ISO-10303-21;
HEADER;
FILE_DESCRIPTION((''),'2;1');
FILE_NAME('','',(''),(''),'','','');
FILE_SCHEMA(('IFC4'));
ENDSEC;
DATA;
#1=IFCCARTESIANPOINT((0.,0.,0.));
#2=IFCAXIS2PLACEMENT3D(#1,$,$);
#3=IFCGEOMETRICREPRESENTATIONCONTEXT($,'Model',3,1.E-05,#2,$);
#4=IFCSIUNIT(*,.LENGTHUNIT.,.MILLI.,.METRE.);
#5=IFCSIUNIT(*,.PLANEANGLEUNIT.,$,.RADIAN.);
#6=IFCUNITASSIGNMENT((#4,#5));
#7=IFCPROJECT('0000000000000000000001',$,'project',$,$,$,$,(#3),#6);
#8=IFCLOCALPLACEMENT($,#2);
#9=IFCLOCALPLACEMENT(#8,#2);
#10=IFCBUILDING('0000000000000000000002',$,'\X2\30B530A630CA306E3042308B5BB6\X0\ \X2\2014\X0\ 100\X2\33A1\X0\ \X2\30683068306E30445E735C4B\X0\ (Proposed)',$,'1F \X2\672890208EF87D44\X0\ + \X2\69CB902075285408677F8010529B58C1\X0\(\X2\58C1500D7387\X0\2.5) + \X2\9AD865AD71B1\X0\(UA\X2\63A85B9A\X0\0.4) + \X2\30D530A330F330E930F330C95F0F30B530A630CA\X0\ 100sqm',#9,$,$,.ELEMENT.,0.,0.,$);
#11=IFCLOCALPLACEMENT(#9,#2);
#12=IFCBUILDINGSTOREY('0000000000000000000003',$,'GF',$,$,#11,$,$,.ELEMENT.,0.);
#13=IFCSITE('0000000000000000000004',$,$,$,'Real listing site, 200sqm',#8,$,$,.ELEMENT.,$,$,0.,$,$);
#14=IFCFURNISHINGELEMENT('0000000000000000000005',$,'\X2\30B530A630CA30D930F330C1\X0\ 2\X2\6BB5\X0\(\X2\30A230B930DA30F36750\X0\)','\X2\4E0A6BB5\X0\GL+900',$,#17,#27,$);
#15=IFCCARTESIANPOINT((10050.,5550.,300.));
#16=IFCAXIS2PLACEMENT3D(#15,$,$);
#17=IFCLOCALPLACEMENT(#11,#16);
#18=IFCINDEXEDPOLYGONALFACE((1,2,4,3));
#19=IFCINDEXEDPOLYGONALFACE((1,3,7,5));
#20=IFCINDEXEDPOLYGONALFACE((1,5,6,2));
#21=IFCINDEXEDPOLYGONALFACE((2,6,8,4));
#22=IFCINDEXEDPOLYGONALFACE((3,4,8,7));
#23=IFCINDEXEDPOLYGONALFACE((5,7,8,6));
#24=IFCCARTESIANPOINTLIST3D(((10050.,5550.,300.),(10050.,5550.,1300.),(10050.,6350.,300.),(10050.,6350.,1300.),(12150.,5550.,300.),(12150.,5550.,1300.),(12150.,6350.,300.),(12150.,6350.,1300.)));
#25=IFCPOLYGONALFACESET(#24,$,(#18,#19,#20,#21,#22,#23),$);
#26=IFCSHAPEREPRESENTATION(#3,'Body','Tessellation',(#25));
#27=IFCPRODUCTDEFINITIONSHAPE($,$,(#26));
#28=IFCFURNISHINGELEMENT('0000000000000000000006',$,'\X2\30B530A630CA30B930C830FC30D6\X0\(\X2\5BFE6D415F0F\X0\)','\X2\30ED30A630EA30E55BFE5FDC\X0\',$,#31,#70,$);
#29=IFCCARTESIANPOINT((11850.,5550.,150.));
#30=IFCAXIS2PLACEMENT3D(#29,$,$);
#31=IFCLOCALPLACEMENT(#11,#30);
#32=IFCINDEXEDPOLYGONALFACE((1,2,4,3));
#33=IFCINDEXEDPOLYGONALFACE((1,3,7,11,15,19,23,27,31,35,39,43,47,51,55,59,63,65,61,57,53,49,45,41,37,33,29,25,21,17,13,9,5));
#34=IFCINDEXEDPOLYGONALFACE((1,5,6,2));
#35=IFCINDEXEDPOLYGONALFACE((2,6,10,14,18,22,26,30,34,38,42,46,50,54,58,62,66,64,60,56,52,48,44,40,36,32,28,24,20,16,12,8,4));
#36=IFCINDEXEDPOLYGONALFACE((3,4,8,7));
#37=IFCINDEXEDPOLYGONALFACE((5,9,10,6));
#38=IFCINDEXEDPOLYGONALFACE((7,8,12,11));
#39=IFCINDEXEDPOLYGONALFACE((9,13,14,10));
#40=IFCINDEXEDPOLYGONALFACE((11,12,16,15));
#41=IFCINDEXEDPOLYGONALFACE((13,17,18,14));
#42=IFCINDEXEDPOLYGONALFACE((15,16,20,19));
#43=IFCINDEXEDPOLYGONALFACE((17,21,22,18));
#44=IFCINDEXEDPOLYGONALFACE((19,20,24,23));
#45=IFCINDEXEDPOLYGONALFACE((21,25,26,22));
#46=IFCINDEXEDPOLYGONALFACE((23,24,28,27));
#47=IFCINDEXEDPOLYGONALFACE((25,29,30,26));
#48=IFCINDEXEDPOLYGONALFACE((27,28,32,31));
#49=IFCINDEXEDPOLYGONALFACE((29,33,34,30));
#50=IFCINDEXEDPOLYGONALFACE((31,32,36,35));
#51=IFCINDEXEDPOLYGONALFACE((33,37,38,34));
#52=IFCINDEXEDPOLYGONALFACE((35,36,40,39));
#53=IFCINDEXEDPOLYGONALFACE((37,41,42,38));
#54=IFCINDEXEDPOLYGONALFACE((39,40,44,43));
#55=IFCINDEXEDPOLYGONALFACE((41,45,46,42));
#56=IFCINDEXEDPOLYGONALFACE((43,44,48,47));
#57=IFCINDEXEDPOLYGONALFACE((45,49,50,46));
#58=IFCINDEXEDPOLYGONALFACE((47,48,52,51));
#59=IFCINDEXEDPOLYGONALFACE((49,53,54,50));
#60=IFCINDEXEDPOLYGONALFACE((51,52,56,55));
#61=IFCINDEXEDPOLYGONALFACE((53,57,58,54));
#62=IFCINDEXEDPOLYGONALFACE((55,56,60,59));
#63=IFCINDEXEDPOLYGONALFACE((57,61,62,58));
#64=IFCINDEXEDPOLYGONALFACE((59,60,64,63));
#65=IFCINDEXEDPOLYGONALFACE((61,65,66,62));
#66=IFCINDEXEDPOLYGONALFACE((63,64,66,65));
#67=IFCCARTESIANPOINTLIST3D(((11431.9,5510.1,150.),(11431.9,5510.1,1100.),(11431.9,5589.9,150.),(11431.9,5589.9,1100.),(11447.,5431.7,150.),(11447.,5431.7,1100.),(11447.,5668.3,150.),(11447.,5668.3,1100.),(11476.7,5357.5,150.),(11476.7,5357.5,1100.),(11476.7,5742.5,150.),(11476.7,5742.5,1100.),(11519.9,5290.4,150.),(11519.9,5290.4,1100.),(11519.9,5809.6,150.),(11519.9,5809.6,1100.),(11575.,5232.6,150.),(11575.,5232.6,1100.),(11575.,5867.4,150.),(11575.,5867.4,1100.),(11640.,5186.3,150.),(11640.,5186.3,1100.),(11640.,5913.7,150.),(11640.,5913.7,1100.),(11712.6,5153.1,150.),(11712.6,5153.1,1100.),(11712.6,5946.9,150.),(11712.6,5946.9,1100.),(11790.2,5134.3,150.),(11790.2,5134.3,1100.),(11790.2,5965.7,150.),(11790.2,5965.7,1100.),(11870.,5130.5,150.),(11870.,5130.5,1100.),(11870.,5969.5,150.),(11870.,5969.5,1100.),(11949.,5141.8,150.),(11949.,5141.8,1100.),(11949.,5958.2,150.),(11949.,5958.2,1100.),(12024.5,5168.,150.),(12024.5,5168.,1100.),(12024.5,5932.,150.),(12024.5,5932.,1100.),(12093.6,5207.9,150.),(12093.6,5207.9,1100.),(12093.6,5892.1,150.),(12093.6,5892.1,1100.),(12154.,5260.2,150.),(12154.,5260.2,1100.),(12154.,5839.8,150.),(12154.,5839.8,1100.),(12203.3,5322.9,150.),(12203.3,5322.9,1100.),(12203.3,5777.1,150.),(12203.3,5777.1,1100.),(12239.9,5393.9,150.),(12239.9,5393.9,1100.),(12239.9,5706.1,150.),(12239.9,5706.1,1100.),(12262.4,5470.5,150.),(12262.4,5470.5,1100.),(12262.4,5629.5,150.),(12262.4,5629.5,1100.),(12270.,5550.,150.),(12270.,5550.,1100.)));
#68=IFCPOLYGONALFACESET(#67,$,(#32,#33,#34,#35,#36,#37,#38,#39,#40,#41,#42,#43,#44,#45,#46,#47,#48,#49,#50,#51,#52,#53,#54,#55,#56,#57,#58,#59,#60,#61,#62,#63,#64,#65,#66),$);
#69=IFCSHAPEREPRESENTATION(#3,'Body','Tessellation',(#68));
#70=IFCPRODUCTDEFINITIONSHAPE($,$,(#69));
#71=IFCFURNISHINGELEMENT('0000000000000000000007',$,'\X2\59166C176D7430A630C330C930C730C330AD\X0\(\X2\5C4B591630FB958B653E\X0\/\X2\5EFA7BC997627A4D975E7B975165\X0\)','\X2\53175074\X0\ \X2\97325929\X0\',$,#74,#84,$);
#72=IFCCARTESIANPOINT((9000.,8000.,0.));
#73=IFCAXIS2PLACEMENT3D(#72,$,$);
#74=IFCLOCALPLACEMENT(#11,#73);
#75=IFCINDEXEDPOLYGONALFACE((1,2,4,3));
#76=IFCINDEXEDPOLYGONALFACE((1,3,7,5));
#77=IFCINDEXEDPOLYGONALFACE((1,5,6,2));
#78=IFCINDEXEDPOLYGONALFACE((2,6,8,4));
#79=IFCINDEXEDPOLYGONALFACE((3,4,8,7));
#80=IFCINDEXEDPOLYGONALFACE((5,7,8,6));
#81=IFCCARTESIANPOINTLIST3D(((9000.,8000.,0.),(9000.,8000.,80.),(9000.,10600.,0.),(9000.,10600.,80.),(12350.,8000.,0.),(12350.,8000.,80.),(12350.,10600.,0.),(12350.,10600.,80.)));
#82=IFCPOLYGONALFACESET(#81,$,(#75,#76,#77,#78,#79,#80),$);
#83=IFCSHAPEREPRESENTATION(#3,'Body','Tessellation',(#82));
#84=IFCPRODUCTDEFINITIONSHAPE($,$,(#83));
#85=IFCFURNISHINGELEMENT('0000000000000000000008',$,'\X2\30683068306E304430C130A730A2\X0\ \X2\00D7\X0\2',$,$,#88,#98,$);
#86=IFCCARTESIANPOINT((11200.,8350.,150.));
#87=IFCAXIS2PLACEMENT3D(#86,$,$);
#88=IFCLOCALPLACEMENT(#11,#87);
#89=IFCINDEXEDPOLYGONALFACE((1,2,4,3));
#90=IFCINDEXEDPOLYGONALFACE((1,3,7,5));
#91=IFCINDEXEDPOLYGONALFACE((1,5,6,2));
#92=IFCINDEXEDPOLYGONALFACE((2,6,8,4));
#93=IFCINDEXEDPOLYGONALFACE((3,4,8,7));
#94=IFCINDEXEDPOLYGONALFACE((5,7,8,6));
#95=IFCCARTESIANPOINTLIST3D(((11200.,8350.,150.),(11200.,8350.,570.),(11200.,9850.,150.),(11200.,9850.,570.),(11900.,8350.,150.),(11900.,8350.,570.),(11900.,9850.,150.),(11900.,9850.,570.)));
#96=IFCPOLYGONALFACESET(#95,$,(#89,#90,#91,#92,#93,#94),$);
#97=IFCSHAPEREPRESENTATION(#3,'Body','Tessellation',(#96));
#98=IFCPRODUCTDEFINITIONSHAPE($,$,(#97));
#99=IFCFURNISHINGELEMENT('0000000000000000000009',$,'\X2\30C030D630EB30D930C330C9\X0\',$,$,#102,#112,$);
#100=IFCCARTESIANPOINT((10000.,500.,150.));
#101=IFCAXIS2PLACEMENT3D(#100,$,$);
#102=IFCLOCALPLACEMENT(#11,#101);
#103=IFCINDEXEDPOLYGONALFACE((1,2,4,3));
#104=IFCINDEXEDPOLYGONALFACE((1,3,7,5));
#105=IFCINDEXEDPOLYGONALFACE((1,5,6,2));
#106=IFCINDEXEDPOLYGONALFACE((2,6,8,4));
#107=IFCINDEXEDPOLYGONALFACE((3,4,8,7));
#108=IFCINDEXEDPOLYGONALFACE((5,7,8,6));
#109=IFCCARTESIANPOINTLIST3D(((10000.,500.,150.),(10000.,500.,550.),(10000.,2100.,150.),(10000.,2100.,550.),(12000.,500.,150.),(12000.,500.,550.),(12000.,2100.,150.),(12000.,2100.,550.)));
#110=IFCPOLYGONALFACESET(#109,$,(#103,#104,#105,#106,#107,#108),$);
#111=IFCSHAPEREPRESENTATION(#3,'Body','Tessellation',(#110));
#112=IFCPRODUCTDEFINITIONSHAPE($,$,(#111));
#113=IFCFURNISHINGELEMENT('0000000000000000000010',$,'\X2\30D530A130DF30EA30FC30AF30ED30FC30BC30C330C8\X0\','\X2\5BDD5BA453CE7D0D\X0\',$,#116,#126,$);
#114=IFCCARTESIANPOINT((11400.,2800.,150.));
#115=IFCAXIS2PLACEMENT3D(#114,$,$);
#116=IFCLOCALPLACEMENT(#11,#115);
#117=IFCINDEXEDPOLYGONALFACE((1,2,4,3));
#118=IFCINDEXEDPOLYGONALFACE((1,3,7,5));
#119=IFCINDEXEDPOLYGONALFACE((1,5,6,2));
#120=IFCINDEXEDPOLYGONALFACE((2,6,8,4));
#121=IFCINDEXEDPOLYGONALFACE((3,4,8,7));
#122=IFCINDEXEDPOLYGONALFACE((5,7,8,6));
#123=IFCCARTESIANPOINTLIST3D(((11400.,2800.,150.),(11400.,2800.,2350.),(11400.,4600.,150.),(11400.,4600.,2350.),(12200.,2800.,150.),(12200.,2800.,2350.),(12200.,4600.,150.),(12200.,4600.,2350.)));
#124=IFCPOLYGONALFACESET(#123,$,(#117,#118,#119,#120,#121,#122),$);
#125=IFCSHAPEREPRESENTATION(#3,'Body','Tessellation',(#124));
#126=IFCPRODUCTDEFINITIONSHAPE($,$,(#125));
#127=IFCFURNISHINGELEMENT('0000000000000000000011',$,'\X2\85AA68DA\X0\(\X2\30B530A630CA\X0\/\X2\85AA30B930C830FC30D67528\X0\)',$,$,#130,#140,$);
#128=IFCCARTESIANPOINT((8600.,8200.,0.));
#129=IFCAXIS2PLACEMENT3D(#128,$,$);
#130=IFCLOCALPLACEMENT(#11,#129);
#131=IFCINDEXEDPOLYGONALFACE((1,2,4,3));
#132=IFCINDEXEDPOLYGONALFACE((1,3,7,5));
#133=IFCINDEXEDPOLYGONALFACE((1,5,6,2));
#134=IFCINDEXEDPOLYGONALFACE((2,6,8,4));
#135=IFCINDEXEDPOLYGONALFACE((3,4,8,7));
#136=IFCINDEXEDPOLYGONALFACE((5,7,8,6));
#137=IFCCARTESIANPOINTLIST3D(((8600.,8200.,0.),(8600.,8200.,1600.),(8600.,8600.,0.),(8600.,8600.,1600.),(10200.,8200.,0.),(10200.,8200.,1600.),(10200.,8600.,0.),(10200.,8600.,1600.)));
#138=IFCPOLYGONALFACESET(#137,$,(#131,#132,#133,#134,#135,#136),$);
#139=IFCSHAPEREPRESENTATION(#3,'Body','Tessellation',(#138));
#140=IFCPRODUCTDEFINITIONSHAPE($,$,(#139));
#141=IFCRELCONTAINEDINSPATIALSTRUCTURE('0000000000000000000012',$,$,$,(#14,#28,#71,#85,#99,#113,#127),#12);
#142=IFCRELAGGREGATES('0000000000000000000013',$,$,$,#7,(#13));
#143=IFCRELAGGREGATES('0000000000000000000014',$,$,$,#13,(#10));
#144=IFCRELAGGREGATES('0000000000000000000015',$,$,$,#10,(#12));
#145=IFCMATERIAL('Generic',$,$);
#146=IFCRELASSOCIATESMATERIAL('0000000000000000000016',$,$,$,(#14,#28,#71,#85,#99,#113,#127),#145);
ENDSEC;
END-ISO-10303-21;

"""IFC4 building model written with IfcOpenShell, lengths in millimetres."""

from ifc_helpers import new_model, si_unit, frame, frame_2d, origin, origin_2d, place, context, project, spatial, rectangle, circle, extrude, material, element, save


model = new_model("IFC4")

# Units and contexts
model_context = context("Model", 3, precision=1e-05, world=origin())
ifc_project = project(units=[si_unit("LENGTHUNIT", "METRE", prefix="MILLI"), si_unit("PLANEANGLEUNIT", "RADIAN")], contexts=[model_context])

# Site, building, storey
site_placement = place(None, origin())
site = spatial("IfcSite", under=ifc_project, at=site_placement, ObjectType="Real listing site, 200sqm", CompositionType="ELEMENT", RefElevation=0.0)
building_placement = place(site_placement, origin())
building = spatial("IfcBuilding", under=site, at=building_placement, Name="サウナのある家 — 100㎡ ととのい平屋 (Proposed)", ObjectType="1F 木造軸組 + 構造用合板耐力壁(壁倍率2.5) + 高断熱(UA推定0.4) + フィンランド式サウナ 100sqm", CompositionType="ELEMENT", ElevationOfRefHeight=0.0, ElevationOfTerrain=0.0)
storey_placement = place(building_placement, origin())
storey = spatial("IfcBuildingStorey", under=building, at=storey_placement, Name="GF", CompositionType="ELEMENT", Elevation=0.0)

# Shared definitions
ifc_material = material(Name="Generic")

# Furnishing elements
furnishing_1_placement = place(storey_placement, frame((10050.0, 5550.0, 300.0)))
element("IfcFurnishingElement", 1, at=furnishing_1_placement, inside=storey, material=ifc_material, Name="サウナベンチ 2段(アスペン材)", Description="上段GL+900", context=model_context, shape_type="SweptSolid", body=[
    extrude(rectangle(XDim=2100.0, YDim=800.0, at=frame_2d((1050.0, 400.0))), frame((10050.0, 5550.0, 300.0)), (0.0, 0.0, 1.0), 1000.0),
])
furnishing_2_placement = place(storey_placement, frame((11850.0, 5550.0, 150.0)))
element("IfcFurnishingElement", 2, at=furnishing_2_placement, inside=storey, material=ifc_material, Name="サウナストーブ(対流式)", Description="ロウリュ対応", context=model_context, shape_type="SweptSolid", body=[
    extrude(circle(Radius=420.0, at=origin_2d()), frame((11850.0, 5550.0, 150.0)), (0.0, 0.0, 1.0), 950.0),
])
furnishing_3_placement = place(storey_placement, frame((9000.0, 8000.0, 0.0)))
element("IfcFurnishingElement", 3, at=furnishing_3_placement, inside=storey, material=ifc_material, Name="外気浴ウッドデッキ(屋外・開放/建築面積非算入)", Description="北側 露天", context=model_context, shape_type="SweptSolid", body=[
    extrude(rectangle(XDim=3350.0, YDim=2600.0, at=frame_2d((1675.0, 1300.0))), frame((9000.0, 8000.0, 0.0)), (0.0, 0.0, 1.0), 80.0),
])
furnishing_4_placement = place(storey_placement, frame((11200.0, 8350.0, 150.0)))
element("IfcFurnishingElement", 4, at=furnishing_4_placement, inside=storey, material=ifc_material, Name="ととのいチェア ×2", context=model_context, shape_type="SweptSolid", body=[
    extrude(rectangle(XDim=700.0, YDim=1500.0, at=frame_2d((350.0, 750.0))), frame((11200.0, 8350.0, 150.0)), (0.0, 0.0, 1.0), 420.0),
])
furnishing_5_placement = place(storey_placement, frame((10000.0, 500.0, 150.0)))
element("IfcFurnishingElement", 5, at=furnishing_5_placement, inside=storey, material=ifc_material, Name="ダブルベッド", context=model_context, shape_type="SweptSolid", body=[
    extrude(rectangle(XDim=2000.0, YDim=1600.0, at=frame_2d((1000.0, 800.0))), frame((10000.0, 500.0, 150.0)), (0.0, 0.0, 1.0), 400.0),
])
furnishing_6_placement = place(storey_placement, frame((11400.0, 2800.0, 150.0)))
element("IfcFurnishingElement", 6, at=furnishing_6_placement, inside=storey, material=ifc_material, Name="ファミリークローゼット", Description="寝室収納", context=model_context, shape_type="SweptSolid", body=[
    extrude(rectangle(XDim=800.0, YDim=1800.0, at=frame_2d((400.0, 900.0))), frame((11400.0, 2800.0, 150.0)), (0.0, 0.0, 1.0), 2200.0),
])
furnishing_7_placement = place(storey_placement, frame((8600.0, 8200.0, 0.0)))
element("IfcFurnishingElement", 7, at=furnishing_7_placement, inside=storey, material=ifc_material, Name="薪棚(サウナ/薪ストーブ用)", context=model_context, shape_type="SweptSolid", body=[
    extrude(rectangle(XDim=1600.0, YDim=400.0, at=frame_2d((800.0, 200.0))), frame((8600.0, 8200.0, 0.0)), (0.0, 0.0, 1.0), 1600.0),
])

save(model, "model.ifc")
